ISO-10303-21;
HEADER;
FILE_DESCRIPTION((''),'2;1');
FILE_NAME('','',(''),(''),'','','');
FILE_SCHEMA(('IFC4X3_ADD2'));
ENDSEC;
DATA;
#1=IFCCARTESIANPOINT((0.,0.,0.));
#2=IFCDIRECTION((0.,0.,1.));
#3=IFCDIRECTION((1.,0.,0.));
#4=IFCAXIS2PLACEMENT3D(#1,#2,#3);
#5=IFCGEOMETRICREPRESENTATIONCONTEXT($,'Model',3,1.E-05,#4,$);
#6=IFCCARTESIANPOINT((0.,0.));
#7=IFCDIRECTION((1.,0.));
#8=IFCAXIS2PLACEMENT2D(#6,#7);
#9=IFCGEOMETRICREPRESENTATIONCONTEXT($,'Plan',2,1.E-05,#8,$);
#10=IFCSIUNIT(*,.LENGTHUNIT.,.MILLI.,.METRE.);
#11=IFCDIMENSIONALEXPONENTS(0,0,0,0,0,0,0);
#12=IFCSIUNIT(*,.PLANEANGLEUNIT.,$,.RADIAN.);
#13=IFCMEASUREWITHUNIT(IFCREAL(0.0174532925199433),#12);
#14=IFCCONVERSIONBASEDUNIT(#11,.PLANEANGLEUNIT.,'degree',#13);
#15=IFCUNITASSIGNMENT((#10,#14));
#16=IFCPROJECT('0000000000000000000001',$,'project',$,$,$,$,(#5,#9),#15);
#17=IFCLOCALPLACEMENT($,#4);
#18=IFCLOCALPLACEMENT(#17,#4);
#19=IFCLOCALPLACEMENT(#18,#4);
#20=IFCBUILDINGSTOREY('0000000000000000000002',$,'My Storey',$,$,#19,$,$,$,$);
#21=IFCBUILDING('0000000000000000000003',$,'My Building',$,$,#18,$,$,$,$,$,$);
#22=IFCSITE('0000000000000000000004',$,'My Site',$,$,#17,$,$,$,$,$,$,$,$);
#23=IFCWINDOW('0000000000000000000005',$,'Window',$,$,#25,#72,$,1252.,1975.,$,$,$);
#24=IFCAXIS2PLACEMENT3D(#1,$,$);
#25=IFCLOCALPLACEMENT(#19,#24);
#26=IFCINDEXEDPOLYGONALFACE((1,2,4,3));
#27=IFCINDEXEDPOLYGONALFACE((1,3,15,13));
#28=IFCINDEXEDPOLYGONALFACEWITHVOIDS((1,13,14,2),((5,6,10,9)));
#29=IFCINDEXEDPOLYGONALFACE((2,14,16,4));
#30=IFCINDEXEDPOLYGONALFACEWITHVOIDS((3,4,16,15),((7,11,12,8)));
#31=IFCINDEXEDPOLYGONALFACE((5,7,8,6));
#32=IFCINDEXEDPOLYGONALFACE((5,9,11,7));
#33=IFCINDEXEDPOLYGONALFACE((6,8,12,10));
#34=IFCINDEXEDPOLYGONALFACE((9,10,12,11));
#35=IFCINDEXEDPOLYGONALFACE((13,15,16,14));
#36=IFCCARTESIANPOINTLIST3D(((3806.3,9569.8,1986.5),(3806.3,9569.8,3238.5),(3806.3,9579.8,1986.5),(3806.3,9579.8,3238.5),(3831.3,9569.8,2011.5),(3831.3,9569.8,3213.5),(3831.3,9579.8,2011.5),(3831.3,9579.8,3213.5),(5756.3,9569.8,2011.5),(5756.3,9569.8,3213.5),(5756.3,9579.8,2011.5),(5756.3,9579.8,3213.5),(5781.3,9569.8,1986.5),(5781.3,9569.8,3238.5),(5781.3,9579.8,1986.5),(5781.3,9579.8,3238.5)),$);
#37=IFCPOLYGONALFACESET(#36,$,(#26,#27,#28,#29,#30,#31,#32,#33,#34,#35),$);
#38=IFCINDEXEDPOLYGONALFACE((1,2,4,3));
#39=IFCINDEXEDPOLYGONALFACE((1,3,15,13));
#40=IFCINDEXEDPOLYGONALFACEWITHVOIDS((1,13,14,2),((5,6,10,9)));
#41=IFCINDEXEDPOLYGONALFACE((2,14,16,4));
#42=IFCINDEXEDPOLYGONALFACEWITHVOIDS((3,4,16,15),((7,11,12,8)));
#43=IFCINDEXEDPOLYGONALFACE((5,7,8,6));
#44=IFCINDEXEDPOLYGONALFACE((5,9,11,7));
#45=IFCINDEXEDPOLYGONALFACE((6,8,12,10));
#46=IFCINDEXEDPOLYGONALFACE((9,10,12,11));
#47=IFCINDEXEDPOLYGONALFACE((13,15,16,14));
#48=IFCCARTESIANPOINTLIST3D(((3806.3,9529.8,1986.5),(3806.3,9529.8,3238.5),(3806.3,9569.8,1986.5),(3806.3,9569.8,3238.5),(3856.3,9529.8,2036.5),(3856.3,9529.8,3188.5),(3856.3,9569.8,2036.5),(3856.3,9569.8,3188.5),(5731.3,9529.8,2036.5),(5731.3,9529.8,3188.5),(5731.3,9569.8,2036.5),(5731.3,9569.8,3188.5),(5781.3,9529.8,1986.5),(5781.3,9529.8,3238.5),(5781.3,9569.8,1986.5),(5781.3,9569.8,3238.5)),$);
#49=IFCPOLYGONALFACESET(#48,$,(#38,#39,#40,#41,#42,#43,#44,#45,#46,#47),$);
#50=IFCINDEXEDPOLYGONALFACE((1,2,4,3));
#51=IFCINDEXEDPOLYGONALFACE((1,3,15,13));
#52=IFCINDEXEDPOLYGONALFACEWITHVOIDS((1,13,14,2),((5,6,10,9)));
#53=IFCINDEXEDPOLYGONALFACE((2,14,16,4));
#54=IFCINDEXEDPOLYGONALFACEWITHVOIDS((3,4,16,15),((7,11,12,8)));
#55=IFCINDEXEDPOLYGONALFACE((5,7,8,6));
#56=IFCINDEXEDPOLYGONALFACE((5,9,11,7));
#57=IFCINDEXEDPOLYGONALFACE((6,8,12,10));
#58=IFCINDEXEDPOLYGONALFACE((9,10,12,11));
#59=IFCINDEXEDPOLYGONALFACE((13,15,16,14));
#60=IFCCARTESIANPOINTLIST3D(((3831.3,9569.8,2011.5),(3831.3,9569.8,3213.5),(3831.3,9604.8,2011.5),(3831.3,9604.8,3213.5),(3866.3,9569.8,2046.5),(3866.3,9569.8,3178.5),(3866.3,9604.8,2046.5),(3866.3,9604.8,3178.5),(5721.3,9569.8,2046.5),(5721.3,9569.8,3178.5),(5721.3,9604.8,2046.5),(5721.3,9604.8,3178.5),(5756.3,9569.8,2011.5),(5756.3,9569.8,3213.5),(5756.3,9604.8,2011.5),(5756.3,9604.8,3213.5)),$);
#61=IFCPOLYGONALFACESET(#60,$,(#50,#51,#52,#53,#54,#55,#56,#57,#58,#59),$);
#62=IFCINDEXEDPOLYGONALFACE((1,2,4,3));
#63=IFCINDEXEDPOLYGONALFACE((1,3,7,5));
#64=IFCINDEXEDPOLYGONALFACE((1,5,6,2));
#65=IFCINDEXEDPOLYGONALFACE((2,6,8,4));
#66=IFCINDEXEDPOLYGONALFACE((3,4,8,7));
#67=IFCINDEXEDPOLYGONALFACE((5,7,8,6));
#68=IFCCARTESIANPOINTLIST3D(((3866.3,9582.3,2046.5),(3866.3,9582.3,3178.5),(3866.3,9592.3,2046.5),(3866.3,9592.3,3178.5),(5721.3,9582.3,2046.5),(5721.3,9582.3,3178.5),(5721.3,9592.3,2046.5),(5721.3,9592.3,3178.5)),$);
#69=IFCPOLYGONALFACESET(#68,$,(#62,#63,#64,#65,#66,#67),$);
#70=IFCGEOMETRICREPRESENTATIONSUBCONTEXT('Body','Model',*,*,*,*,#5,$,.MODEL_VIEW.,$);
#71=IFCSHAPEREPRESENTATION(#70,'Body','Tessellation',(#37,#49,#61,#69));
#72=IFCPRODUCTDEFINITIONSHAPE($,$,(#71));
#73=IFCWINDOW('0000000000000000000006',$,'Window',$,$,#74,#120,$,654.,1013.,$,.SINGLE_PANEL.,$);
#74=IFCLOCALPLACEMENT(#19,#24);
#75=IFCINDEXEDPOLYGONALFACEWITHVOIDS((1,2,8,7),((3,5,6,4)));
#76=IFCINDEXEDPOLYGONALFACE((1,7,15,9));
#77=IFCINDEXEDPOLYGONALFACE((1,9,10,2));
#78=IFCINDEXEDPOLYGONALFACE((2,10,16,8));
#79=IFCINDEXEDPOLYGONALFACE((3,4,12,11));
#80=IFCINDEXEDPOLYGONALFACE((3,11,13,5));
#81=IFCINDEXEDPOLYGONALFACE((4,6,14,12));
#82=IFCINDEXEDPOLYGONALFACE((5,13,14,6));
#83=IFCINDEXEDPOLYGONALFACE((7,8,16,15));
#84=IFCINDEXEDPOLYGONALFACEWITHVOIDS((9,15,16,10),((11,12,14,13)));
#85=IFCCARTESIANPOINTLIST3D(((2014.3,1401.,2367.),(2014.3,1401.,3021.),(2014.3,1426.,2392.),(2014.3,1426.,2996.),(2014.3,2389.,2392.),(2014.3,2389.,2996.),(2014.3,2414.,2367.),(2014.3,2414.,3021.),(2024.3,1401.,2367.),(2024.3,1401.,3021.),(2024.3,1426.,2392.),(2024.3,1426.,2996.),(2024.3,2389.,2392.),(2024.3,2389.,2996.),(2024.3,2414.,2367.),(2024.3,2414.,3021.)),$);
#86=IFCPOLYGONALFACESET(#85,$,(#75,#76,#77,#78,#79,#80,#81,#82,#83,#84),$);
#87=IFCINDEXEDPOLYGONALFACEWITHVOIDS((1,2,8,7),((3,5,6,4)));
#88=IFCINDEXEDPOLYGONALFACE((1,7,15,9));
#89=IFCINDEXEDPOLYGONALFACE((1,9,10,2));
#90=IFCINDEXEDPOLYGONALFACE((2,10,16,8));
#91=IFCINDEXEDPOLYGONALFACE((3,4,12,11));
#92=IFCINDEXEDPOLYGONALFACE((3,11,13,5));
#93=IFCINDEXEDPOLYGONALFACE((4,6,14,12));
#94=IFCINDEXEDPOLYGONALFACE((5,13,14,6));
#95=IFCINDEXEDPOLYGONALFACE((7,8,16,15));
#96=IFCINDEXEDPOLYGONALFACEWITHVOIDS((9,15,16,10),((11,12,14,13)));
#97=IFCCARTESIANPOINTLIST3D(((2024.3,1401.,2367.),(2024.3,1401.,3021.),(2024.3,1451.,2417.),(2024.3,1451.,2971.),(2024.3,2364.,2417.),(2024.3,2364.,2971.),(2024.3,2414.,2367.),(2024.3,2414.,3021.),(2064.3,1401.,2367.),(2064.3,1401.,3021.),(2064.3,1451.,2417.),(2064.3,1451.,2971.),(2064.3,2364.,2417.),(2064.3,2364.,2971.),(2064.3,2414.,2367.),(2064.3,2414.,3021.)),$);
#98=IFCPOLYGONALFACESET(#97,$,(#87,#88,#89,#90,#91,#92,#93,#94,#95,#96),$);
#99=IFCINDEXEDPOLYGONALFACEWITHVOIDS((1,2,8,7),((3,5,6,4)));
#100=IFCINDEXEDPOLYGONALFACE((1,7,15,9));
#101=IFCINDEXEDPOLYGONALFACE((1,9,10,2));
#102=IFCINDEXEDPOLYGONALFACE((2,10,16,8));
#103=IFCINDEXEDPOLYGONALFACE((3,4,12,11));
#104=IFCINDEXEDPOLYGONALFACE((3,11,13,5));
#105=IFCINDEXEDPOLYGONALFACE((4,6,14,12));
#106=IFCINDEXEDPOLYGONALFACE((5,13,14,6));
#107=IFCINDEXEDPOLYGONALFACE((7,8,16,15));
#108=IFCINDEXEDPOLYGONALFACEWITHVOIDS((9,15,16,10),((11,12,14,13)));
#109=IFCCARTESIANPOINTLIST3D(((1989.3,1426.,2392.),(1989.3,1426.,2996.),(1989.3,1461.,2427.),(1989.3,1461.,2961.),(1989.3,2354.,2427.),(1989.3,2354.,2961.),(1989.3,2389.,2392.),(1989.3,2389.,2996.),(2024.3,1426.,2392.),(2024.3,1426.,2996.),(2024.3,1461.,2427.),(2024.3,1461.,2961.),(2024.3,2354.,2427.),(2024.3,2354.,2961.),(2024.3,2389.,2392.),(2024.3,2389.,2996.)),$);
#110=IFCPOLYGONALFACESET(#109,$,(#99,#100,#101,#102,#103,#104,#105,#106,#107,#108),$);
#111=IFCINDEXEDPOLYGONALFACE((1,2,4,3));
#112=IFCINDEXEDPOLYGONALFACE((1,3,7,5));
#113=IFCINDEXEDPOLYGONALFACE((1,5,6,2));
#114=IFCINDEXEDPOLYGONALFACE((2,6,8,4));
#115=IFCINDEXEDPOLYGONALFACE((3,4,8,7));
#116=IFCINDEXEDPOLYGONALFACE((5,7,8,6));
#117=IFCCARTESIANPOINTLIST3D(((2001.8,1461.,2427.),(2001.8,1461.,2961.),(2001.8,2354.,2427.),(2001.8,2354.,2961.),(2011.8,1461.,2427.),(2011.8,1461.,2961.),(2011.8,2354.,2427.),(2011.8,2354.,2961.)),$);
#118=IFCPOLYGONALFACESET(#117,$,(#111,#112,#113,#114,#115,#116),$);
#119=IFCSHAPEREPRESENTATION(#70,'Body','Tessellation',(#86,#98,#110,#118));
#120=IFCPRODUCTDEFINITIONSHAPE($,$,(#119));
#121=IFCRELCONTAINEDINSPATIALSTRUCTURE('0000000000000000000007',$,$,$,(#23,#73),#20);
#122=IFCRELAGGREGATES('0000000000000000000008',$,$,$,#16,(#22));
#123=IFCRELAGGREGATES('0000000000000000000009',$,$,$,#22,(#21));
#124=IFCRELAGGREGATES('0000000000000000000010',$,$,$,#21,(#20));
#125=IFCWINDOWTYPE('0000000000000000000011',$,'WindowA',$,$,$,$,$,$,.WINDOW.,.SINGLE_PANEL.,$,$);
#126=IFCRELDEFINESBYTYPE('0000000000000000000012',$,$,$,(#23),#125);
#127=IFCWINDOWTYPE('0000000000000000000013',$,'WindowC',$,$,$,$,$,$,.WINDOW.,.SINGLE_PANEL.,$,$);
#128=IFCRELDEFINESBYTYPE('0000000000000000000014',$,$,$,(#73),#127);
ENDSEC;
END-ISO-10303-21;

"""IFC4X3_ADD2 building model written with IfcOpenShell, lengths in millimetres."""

from ifc_helpers import new_model, entity, si_unit, converted_unit, frame, origin_with_axes, origin_2d_with_axis, place, context, subcontext, project, spatial, line, indexed_curve, outline, extrude, shape, source, transform, mapped, type_object, type_shapes, element, save


model = new_model("IFC4X3_ADD2")

# Units and contexts
model_context = context("Model", 3, precision=1e-05, world=origin_with_axes())
plan_context = context("Plan", 2, precision=1e-05, world=origin_2d_with_axis())
body_context_1 = subcontext(model_context, "Body", "Model", "MODEL_VIEW")
body_context_2 = subcontext(plan_context, "Body", "Plan", "PLAN_VIEW")
ifc_project = project(units=[si_unit("LENGTHUNIT", "METRE", prefix="MILLI"), converted_unit("PLANEANGLEUNIT", "degree", entity("IfcReal", 0.0174532925199433), si_unit("PLANEANGLEUNIT", "RADIAN"), dimensions=[0, 0, 0, 0, 0, 0, 0])], contexts=[model_context, plan_context])

# Site, building, storey
site_placement = place(None, origin_with_axes())
site = spatial("IfcSite", under=ifc_project, at=site_placement, Name="My Site")
building_placement = place(site_placement, origin_with_axes())
building = spatial("IfcBuilding", under=site, at=building_placement, Name="My Building")
storey_placement = place(building_placement, origin_with_axes())
storey = spatial("IfcBuildingStorey", under=building, at=storey_placement, Name="My Storey")

# Windows
window_type_1 = type_object("IfcWindowType", Name="WindowA", PartitioningType="SINGLE_PANEL", PredefinedType="WINDOW")
shared_shape_1 = source(origin_with_axes(), body_context_1, "Body", "SweptSolid", [
    extrude(outline(indexed_curve([(0.0, 0.0), (1975.0, 0.0), (1975.0, 1252.0), (0.0, 1252.0)], segments=[line(1, 2, 3, 4, 1)]), holes=[indexed_curve([(25.0, 25.0), (1950.0, 25.0), (1950.0, 1227.0), (25.0, 1227.0)], segments=[line(1, 2, 3, 4, 1)])]), frame((0.0, 90.0, 0.0), z_axis=(0.0, -1.0, 0.0), x_axis=(1.0, 0.0, 0.0)), (0.0, 0.0, -1.0), 10.0),
    extrude(outline(indexed_curve([(0.0, 0.0), (1975.0, 0.0), (1975.0, 1252.0), (0.0, 1252.0)], segments=[line(1, 2, 3, 4, 1)]), holes=[indexed_curve([(50.0, 50.0), (1925.0, 50.0), (1925.0, 1202.0), (50.0, 1202.0)], segments=[line(1, 2, 3, 4, 1)])]), frame((0.0, 50.0, 0.0), z_axis=(0.0, -1.0, 0.0), x_axis=(1.0, 0.0, 0.0)), (0.0, 0.0, -1.0), 40.0),
    extrude(outline(indexed_curve([(0.0, 0.0), (1925.0, 0.0), (1925.0, 1202.0), (0.0, 1202.0)], segments=[line(1, 2, 3, 4, 1)]), holes=[indexed_curve([(35.0, 35.0), (1890.0, 35.0), (1890.0, 1167.0), (35.0, 1167.0)], segments=[line(1, 2, 3, 4, 1)])]), frame((25.0, 90.0, 25.0), z_axis=(0.0, -1.0, 0.0), x_axis=(1.0, 0.0, 0.0)), (0.0, 0.0, -1.0), 35.0),
    extrude(outline(indexed_curve([(35.0, 35.0), (1890.0, 35.0), (1890.0, 1167.0), (35.0, 1167.0)], segments=[line(1, 2, 3, 4, 1)])), frame((25.0, 102.5, 25.0), z_axis=(0.0, -1.0, 0.0), x_axis=(1.0, 0.0, 0.0)), (0.0, 0.0, -1.0), 10.0),
])
shared_shape_2 = source(origin_with_axes(), body_context_2, "Body", "Curve2D", [
    entity("IfcIndexedPolyCurve", entity("IfcCartesianPointList2D", [[50.0, 50.0], [1925.0, 50.0]])),
    entity("IfcIndexedPolyCurve", entity("IfcCartesianPointList2D", [[0.0, 100.0], [25.0, 100.0], [25.0, 90.0], [50.0, 90.0], [50.0, 50.0], [0.0, 50.0]]), [entity("IfcLineIndex", [1, 2, 3, 4, 5, 6, 1])]),
    entity("IfcIndexedPolyCurve", entity("IfcCartesianPointList2D", [[1975.0, 100.0], [1950.0, 100.0], [1950.0, 90.0], [1925.0, 90.0], [1925.0, 50.0], [1975.0, 50.0]]), [entity("IfcLineIndex", [1, 2, 3, 4, 5, 6, 1])]),
    entity("IfcIndexedPolyCurve", entity("IfcCartesianPointList2D", [[25.0, 90.0], [60.0, 90.0], [60.0, 125.0], [25.0, 125.0]]), [entity("IfcLineIndex", [1, 2, 3, 4, 1])]),
    entity("IfcIndexedPolyCurve", entity("IfcCartesianPointList2D", [[1950.0, 90.0], [1915.0, 90.0], [1915.0, 125.0], [1950.0, 125.0]]), [entity("IfcLineIndex", [1, 2, 3, 4, 1])]),
    entity("IfcIndexedPolyCurve", entity("IfcCartesianPointList2D", [[60.0, 90.0], [1915.0, 90.0]])),
    entity("IfcIndexedPolyCurve", entity("IfcCartesianPointList2D", [[60.0, 125.0], [1915.0, 125.0]])),
    entity("IfcIndexedPolyCurve", entity("IfcCartesianPointList2D", [[60.0, 107.5], [1915.0, 107.5]])),
])
type_shapes(window_type_1, [shared_shape_1, shared_shape_2])
window_1_placement = place(storey_placement, frame((3806.3, 9479.8, 1986.5), z_axis=(0.0, 0.0, 1.0), x_axis=(1.0, 0.0, 0.0)))
element("IfcWindow", 1, at=window_1_placement, inside=storey, type_object=window_type_1, Name="Window", OverallHeight=1252.0, OverallWidth=1975.0, shapes=[
    shape(body_context_1, "Body", "MappedRepresentation", [mapped(shared_shape_1, transform((0.0, 0.0, 0.0), x_axis=(1.0, 0.0, 0.0), y_axis=(0.0, 1.0, 0.0), z_axis=(0.0, 0.0, 1.0), scale=1.0))]),
    shape(body_context_2, "Body", "MappedRepresentation", [mapped(shared_shape_2, transform((0.0, 0.0, 0.0), x_axis=(1.0, 0.0, 0.0), y_axis=(0.0, 1.0, 0.0), z_axis=(0.0, 0.0, 1.0), scale=1.0))]),
])
window_type_2 = type_object("IfcWindowType", Name="WindowC", PartitioningType="SINGLE_PANEL", PredefinedType="WINDOW")
shared_shape_3 = source(origin_with_axes(), body_context_1, "Body", "SweptSolid", [
    extrude(outline(indexed_curve([(0.0, 0.0), (1013.0, 0.0), (1013.0, 654.0), (0.0, 654.0)], segments=[line(1, 2, 3, 4, 1)]), holes=[indexed_curve([(25.0, 25.0), (988.0, 25.0), (988.0, 629.0), (25.0, 629.0)], segments=[line(1, 2, 3, 4, 1)])]), frame((0.0, 90.0, 0.0), z_axis=(0.0, -1.0, 0.0), x_axis=(1.0, 0.0, 0.0)), (0.0, 0.0, -1.0), 10.0),
    extrude(outline(indexed_curve([(0.0, 0.0), (1013.0, 0.0), (1013.0, 654.0), (0.0, 654.0)], segments=[line(1, 2, 3, 4, 1)]), holes=[indexed_curve([(50.0, 50.0), (963.0, 50.0), (963.0, 604.0), (50.0, 604.0)], segments=[line(1, 2, 3, 4, 1)])]), frame((0.0, 50.0, 0.0), z_axis=(0.0, -1.0, 0.0), x_axis=(1.0, 0.0, 0.0)), (0.0, 0.0, -1.0), 40.0),
    extrude(outline(indexed_curve([(0.0, 0.0), (963.0, 0.0), (963.0, 604.0), (0.0, 604.0)], segments=[line(1, 2, 3, 4, 1)]), holes=[indexed_curve([(35.0, 35.0), (928.0, 35.0), (928.0, 569.0), (35.0, 569.0)], segments=[line(1, 2, 3, 4, 1)])]), frame((25.0, 90.0, 25.0), z_axis=(0.0, -1.0, 0.0), x_axis=(1.0, 0.0, 0.0)), (0.0, 0.0, -1.0), 35.0),
    extrude(outline(indexed_curve([(35.0, 35.0), (928.0, 35.0), (928.0, 569.0), (35.0, 569.0)], segments=[line(1, 2, 3, 4, 1)])), frame((25.0, 102.5, 25.0), z_axis=(0.0, -1.0, 0.0), x_axis=(1.0, 0.0, 0.0)), (0.0, 0.0, -1.0), 10.0),
])
shared_shape_4 = source(origin_with_axes(), body_context_2, "Body", "Curve2D", [
    entity("IfcIndexedPolyCurve", entity("IfcCartesianPointList2D", [[50.0, 50.0], [963.0, 50.0]])),
    entity("IfcIndexedPolyCurve", entity("IfcCartesianPointList2D", [[0.0, 100.0], [25.0, 100.0], [25.0, 90.0], [50.0, 90.0], [50.0, 50.0], [0.0, 50.0]]), [entity("IfcLineIndex", [1, 2, 3, 4, 5, 6, 1])]),
    entity("IfcIndexedPolyCurve", entity("IfcCartesianPointList2D", [[1013.0, 100.0], [988.0, 100.0], [988.0, 90.0], [963.0, 90.0], [963.0, 50.0], [1013.0, 50.0]]), [entity("IfcLineIndex", [1, 2, 3, 4, 5, 6, 1])]),
    entity("IfcIndexedPolyCurve", entity("IfcCartesianPointList2D", [[25.0, 90.0], [60.0, 90.0], [60.0, 125.0], [25.0, 125.0]]), [entity("IfcLineIndex", [1, 2, 3, 4, 1])]),
    entity("IfcIndexedPolyCurve", entity("IfcCartesianPointList2D", [[988.0, 90.0], [953.0, 90.0], [953.0, 125.0], [988.0, 125.0]]), [entity("IfcLineIndex", [1, 2, 3, 4, 1])]),
    entity("IfcIndexedPolyCurve", entity("IfcCartesianPointList2D", [[60.0, 90.0], [953.0, 90.0]])),
    entity("IfcIndexedPolyCurve", entity("IfcCartesianPointList2D", [[60.0, 125.0], [953.0, 125.0]])),
    entity("IfcIndexedPolyCurve", entity("IfcCartesianPointList2D", [[60.0, 107.5], [953.0, 107.5]])),
])
type_shapes(window_type_2, [shared_shape_3, shared_shape_4])
window_2_placement = place(storey_placement, frame((2114.3, 1401.0, 2367.0), z_axis=(0.0, 0.0, 1.0), x_axis=(0.0, 1.0, 0.0)))
element("IfcWindow", 2, at=window_2_placement, inside=storey, type_object=window_type_2, Name="Window", OverallHeight=654.0, OverallWidth=1013.0, PartitioningType="SINGLE_PANEL", shapes=[
    shape(body_context_1, "Body", "MappedRepresentation", [mapped(shared_shape_3, transform((0.0, 0.0, 0.0), x_axis=(1.0, 0.0, 0.0), y_axis=(0.0, 1.0, 0.0), z_axis=(0.0, 0.0, 1.0), scale=1.0))]),
    shape(body_context_2, "Body", "MappedRepresentation", [mapped(shared_shape_4, transform((0.0, 0.0, 0.0), x_axis=(1.0, 0.0, 0.0), y_axis=(0.0, 1.0, 0.0), z_axis=(0.0, 0.0, 1.0), scale=1.0))]),
])

save(model, "model.ifc")
